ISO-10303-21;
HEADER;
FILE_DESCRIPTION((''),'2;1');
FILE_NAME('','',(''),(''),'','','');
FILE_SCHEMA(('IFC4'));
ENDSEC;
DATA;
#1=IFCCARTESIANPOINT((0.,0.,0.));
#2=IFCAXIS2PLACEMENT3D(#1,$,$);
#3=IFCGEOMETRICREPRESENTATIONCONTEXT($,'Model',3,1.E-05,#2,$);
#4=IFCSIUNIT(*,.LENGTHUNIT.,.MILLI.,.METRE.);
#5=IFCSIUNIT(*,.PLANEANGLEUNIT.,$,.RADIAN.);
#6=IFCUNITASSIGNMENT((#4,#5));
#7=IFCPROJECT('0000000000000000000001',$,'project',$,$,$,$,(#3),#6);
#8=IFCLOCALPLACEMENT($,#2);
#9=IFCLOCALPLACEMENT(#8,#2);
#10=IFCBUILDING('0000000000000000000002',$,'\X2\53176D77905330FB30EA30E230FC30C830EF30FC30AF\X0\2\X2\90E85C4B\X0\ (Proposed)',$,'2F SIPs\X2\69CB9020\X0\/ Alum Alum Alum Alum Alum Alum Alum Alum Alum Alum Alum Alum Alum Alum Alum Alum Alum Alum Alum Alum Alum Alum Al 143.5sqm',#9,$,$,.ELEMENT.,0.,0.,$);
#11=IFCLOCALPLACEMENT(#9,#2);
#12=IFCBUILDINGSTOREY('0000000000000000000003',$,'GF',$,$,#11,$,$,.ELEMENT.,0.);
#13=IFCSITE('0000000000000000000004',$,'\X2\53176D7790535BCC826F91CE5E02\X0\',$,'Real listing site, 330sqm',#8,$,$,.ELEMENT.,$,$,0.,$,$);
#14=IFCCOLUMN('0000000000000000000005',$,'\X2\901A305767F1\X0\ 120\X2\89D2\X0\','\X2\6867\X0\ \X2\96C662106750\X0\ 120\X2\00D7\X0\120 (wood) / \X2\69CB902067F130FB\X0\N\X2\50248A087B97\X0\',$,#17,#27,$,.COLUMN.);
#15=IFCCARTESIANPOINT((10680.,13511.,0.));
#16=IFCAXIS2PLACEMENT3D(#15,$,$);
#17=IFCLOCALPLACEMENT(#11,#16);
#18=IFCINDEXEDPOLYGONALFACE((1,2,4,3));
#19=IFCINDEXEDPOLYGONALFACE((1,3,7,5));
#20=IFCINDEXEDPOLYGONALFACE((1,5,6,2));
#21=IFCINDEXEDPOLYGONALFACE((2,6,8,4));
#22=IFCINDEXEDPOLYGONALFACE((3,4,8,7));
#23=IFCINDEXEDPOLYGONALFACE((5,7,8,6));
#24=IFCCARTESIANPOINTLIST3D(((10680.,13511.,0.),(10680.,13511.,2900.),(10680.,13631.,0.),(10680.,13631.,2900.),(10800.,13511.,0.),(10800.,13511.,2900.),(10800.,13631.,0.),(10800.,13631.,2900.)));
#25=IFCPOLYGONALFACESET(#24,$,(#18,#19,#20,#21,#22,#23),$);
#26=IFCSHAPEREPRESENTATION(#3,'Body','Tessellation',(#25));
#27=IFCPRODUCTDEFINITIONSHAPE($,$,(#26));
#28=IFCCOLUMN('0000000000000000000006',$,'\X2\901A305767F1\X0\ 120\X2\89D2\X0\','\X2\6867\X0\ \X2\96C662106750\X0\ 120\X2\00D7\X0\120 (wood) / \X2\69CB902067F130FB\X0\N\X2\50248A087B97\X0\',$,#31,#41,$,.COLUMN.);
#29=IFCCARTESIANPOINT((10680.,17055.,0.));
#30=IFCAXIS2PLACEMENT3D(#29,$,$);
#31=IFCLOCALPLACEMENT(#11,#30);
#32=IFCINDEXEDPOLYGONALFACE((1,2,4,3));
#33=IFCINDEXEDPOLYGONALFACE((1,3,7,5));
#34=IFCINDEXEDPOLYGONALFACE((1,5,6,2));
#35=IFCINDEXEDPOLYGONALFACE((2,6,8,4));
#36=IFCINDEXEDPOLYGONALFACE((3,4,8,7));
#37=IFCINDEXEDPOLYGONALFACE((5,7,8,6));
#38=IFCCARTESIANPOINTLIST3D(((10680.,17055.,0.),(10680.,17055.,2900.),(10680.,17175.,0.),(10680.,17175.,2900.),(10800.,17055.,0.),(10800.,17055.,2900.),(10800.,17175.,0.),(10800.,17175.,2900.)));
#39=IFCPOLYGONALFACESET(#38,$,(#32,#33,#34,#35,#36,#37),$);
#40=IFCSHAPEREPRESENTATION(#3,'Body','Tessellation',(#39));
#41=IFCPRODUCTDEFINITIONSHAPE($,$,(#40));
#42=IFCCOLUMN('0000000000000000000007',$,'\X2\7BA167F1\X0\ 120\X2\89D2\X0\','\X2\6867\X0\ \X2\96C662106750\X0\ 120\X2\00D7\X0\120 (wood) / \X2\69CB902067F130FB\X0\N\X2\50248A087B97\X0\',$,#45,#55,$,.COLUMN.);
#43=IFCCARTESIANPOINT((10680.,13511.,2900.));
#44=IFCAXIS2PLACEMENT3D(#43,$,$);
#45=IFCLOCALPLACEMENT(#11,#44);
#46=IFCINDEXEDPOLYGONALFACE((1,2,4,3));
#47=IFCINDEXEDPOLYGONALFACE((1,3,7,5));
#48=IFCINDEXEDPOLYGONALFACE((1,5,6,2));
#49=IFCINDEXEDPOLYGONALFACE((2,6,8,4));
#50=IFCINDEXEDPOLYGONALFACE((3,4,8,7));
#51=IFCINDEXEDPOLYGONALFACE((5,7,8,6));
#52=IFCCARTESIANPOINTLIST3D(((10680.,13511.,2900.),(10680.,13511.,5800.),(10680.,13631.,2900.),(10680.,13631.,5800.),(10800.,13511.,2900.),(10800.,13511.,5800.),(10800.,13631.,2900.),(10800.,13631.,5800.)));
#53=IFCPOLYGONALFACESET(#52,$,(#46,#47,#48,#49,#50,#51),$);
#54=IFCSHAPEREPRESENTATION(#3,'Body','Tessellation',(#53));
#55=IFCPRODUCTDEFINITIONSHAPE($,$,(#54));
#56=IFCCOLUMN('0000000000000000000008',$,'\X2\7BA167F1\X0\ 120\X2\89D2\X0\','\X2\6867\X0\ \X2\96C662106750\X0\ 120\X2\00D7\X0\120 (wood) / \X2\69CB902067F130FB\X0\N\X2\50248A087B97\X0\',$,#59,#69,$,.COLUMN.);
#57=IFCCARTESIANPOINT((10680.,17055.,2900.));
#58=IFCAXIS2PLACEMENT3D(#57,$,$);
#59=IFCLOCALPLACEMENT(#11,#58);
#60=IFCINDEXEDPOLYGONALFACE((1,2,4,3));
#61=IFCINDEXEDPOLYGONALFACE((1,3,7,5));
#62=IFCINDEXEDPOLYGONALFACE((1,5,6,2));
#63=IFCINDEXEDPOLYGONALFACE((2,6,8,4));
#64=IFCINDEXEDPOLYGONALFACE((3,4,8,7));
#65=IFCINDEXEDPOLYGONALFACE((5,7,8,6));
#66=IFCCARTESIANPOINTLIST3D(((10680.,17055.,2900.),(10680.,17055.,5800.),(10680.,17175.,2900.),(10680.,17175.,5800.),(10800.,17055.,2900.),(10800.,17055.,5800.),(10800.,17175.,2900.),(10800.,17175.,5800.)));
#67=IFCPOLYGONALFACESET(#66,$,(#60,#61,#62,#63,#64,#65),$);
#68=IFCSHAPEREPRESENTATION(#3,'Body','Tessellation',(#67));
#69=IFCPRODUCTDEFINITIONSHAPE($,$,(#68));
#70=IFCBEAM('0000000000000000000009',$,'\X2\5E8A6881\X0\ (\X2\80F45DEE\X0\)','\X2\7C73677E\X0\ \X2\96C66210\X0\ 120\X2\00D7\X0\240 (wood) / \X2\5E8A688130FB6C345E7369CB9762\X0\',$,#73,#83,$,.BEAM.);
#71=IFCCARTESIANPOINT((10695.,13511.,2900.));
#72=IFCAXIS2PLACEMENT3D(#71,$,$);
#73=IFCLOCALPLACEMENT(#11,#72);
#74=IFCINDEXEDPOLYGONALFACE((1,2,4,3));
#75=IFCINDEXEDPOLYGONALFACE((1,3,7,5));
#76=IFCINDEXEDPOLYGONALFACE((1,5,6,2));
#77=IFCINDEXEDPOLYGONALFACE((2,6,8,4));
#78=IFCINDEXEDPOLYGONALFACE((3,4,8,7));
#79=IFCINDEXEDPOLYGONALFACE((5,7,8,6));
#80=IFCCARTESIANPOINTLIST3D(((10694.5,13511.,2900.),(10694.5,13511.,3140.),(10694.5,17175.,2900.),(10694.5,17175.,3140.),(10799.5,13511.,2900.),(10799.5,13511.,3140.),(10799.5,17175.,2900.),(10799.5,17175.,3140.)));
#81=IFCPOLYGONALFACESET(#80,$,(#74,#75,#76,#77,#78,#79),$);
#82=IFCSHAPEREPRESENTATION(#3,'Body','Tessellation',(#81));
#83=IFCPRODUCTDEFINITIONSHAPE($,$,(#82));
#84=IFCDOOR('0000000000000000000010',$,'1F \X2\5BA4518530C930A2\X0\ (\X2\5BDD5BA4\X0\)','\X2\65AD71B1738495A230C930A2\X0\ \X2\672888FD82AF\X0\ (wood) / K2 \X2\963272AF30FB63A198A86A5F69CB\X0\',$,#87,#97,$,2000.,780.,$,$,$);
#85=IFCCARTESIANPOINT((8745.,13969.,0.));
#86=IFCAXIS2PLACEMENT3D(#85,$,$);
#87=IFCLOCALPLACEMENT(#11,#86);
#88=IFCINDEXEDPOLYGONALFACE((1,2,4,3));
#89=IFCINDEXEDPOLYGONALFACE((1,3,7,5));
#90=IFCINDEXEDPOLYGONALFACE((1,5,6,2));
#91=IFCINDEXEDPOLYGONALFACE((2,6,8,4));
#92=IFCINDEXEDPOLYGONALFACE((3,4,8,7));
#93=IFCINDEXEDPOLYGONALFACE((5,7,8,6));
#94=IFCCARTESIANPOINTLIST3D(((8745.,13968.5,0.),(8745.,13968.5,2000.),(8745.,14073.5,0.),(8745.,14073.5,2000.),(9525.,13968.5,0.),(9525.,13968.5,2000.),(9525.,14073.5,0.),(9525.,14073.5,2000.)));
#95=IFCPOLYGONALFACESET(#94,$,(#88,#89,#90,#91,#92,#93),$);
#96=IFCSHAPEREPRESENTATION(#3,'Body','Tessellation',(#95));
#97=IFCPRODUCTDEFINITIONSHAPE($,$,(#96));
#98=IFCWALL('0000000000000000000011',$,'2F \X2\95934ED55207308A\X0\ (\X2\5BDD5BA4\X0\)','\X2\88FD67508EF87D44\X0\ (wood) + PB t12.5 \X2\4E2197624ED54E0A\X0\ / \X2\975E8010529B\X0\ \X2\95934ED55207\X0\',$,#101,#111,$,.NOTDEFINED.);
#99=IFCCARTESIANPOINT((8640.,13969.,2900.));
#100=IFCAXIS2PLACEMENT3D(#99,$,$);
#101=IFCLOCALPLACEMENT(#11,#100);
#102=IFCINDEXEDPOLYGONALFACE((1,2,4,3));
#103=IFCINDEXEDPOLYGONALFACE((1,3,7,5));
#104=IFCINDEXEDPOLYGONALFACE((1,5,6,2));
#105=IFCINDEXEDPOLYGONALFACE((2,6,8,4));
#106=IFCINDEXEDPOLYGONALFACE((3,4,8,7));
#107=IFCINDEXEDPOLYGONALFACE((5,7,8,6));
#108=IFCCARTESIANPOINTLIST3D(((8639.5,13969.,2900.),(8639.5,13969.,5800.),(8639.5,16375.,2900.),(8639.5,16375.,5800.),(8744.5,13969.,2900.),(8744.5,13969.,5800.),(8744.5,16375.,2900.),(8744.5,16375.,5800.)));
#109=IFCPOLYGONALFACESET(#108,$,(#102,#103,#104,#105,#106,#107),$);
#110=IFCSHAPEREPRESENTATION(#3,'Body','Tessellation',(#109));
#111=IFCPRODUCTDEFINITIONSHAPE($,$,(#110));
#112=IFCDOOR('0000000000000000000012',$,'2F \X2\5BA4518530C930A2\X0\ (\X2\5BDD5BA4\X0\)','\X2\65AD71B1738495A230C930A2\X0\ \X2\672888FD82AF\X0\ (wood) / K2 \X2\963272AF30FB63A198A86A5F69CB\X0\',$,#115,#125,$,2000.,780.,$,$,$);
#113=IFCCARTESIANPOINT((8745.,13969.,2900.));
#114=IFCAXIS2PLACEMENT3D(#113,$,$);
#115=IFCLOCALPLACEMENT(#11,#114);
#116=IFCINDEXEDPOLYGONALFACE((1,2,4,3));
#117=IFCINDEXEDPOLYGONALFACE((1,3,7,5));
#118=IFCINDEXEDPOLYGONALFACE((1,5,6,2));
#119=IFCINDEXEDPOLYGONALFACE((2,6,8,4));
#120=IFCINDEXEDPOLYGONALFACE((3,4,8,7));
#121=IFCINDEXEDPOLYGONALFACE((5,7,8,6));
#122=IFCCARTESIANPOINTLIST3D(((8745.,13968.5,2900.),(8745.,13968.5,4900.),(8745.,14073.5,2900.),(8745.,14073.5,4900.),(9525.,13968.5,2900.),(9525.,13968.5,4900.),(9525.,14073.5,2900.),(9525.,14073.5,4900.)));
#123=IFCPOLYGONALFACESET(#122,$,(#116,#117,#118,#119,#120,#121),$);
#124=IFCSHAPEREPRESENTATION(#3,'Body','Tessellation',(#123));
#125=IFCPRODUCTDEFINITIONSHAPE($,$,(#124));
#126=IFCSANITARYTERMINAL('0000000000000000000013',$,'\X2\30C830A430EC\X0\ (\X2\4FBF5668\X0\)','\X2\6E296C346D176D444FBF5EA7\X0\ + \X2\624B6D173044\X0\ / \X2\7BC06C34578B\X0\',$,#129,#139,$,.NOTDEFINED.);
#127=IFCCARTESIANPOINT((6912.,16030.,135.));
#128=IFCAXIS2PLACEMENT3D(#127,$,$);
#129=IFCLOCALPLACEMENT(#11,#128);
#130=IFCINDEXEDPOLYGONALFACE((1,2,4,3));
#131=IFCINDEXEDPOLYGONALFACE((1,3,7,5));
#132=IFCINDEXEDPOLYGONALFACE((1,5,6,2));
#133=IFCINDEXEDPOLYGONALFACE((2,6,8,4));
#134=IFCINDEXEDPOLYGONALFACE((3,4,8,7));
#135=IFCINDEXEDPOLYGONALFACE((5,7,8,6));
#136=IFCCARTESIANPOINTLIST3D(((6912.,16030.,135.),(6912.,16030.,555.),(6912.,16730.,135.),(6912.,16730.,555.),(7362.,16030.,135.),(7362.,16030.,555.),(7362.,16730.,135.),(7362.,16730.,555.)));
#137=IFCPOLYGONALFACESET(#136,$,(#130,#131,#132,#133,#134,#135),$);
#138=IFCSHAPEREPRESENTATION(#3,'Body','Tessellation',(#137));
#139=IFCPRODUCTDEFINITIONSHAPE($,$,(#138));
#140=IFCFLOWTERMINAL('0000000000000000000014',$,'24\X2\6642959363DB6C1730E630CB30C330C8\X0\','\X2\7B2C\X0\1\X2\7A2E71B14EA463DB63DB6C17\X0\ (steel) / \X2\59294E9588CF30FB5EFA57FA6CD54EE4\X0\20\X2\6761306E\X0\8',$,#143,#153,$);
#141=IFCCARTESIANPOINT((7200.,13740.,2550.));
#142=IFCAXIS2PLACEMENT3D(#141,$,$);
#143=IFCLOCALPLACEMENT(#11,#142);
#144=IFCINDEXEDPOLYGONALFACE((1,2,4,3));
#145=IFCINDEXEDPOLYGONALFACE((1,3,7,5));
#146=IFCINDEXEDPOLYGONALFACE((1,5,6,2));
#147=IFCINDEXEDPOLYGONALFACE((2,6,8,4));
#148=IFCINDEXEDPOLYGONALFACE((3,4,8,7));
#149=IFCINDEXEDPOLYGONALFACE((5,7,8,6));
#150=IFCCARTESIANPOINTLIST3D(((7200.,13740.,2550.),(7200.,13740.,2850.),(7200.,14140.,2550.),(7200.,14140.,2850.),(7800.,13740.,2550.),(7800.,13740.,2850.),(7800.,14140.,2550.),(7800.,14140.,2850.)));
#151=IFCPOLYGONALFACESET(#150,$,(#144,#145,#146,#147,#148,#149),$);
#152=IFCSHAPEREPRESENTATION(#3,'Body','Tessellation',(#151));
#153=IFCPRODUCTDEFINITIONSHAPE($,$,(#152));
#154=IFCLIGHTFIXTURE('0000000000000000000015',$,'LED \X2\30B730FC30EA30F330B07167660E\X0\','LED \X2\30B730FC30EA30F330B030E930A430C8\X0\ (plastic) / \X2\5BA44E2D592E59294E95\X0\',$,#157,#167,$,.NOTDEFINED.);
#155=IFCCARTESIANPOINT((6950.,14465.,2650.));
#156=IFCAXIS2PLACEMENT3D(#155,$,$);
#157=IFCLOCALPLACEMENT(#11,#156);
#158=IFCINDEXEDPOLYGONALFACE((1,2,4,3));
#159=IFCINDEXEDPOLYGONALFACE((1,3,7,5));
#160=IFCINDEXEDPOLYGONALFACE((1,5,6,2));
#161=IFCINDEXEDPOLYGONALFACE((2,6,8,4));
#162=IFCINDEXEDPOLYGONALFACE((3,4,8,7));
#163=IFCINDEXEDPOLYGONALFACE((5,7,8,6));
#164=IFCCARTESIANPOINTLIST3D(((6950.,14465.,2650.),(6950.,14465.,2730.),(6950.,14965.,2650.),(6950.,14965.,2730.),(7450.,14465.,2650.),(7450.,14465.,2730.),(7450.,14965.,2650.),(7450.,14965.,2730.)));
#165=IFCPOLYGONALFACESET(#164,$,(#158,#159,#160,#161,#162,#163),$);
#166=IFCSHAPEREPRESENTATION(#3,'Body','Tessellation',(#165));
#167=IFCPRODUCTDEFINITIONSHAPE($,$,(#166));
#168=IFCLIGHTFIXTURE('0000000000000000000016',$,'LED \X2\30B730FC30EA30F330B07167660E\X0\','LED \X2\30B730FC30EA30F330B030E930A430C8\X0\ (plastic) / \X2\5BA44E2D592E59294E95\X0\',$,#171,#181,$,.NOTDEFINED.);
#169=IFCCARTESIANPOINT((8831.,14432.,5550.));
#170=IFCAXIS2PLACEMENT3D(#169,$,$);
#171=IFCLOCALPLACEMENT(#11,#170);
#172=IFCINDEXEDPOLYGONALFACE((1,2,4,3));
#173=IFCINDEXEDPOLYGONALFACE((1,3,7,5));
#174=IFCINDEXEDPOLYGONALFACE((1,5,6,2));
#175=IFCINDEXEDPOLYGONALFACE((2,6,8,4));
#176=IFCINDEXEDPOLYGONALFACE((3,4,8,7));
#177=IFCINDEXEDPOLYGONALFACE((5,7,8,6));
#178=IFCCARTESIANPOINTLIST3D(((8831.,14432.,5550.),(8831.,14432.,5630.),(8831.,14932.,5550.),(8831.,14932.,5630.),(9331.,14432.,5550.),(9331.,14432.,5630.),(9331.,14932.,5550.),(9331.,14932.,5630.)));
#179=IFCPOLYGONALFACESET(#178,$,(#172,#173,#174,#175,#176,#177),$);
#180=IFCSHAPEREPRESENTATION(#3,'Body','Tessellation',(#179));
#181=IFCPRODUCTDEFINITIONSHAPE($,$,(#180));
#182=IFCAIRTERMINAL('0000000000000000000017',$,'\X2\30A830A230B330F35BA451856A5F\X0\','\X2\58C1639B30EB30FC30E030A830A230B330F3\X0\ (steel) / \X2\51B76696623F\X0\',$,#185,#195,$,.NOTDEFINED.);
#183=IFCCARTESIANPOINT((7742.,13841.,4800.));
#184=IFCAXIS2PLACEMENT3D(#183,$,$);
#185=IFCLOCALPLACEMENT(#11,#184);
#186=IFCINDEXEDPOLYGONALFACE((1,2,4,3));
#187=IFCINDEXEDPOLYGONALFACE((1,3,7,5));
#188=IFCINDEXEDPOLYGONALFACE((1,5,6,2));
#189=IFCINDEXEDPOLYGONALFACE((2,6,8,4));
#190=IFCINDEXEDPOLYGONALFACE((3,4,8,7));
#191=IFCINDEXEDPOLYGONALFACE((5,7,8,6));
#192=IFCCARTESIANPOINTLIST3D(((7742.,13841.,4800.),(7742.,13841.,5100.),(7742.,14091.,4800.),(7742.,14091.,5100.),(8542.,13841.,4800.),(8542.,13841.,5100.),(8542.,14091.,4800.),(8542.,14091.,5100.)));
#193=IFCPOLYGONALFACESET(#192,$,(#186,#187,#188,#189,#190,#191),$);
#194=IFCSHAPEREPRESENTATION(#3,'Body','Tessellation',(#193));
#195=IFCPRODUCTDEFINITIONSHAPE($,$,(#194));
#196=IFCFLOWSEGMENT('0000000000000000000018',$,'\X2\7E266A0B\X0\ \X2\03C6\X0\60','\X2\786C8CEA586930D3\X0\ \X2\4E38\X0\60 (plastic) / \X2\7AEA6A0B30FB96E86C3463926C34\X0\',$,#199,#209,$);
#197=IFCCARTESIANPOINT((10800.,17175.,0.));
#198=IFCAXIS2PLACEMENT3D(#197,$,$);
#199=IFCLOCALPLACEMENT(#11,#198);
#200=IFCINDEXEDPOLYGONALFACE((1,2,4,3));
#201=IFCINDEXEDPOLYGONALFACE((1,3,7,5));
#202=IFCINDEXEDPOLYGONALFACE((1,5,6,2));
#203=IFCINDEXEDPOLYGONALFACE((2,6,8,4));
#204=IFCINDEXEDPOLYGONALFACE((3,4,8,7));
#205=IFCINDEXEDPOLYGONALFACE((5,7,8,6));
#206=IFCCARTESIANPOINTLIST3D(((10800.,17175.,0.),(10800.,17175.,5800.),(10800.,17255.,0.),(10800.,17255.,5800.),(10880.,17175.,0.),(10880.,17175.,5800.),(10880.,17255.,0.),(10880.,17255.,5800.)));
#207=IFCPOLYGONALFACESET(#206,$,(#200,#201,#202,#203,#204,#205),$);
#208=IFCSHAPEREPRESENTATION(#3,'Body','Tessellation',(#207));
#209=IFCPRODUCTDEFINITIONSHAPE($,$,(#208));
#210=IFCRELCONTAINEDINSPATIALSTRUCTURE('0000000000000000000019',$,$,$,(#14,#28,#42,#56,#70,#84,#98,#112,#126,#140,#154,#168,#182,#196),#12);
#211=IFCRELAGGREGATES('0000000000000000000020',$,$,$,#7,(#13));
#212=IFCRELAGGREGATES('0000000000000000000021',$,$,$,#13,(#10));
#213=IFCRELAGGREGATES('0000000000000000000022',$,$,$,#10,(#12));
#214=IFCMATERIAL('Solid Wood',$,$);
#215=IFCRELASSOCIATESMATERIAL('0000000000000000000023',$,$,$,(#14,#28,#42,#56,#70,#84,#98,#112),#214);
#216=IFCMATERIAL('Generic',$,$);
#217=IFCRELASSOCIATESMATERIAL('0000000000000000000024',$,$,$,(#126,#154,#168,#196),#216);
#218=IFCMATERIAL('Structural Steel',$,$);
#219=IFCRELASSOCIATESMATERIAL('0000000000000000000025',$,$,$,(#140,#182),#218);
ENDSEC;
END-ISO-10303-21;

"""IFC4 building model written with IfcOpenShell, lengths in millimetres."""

from ifc_helpers import new_model, si_unit, frame, frame_2d, origin, place, context, project, spatial, rectangle, extrude, material, element, save


model = new_model("IFC4")

# Units and contexts
model_context = context("Model", 3, precision=1e-05, world=origin())
ifc_project = project(units=[si_unit("LENGTHUNIT", "METRE", prefix="MILLI"), si_unit("PLANEANGLEUNIT", "RADIAN")], contexts=[model_context])

# Site, building, storey
site_placement = place(None, origin())
site = spatial("IfcSite", under=ifc_project, at=site_placement, Name="北海道富良野市", ObjectType="Real listing site, 330sqm", CompositionType="ELEMENT", RefElevation=0.0)
building_placement = place(site_placement, origin())
building = spatial("IfcBuilding", under=site, at=building_placement, Name="北海道・リモートワーク2部屋 (Proposed)", ObjectType="2F SIPs構造/ Alum Alum Alum Alum Alum Alum Alum Alum Alum Alum Alum Alum Alum Alum Alum Alum Alum Alum Alum Alum Alum Alum Al 143.5sqm", CompositionType="ELEMENT", ElevationOfRefHeight=0.0, ElevationOfTerrain=0.0)
storey_placement = place(building_placement, origin())
storey = spatial("IfcBuildingStorey", under=building, at=storey_placement, Name="GF", CompositionType="ELEMENT", Elevation=0.0)

# Columns
ifc_material_1 = material(Name="Solid Wood")
column_1_placement = place(storey_placement, frame((10680.0, 13511.0, 0.0)))
element("IfcColumn", 1, at=column_1_placement, inside=storey, material=ifc_material_1, Name="通し柱 120角", Description="桧 集成材 120×120 (wood) / 構造柱・N値計算", PredefinedType="COLUMN", context=model_context, shape_type="SweptSolid", body=[
    extrude(rectangle(XDim=120.0, YDim=120.0, at=frame_2d((60.0, 60.0))), frame((10680.0, 13511.0, 0.0)), (0.0, 0.0, 1.0), 2900.0),
])
column_2_placement = place(storey_placement, frame((10680.0, 17055.0, 0.0)))
element("IfcColumn", 2, at=column_2_placement, inside=storey, material=ifc_material_1, Name="通し柱 120角", Description="桧 集成材 120×120 (wood) / 構造柱・N値計算", PredefinedType="COLUMN", context=model_context, shape_type="SweptSolid", body=[
    extrude(rectangle(XDim=120.0, YDim=120.0, at=frame_2d((60.0, 60.0))), frame((10680.0, 17055.0, 0.0)), (0.0, 0.0, 1.0), 2900.0),
])
column_3_placement = place(storey_placement, frame((10680.0, 13511.0, 2900.0)))
element("IfcColumn", 3, at=column_3_placement, inside=storey, material=ifc_material_1, Name="管柱 120角", Description="桧 集成材 120×120 (wood) / 構造柱・N値計算", PredefinedType="COLUMN", context=model_context, shape_type="SweptSolid", body=[
    extrude(rectangle(XDim=120.0, YDim=120.0, at=frame_2d((60.0, 60.0))), frame((10680.0, 13511.0, 2900.0)), (0.0, 0.0, 1.0), 2900.0),
])
column_4_placement = place(storey_placement, frame((10680.0, 17055.0, 2900.0)))
element("IfcColumn", 4, at=column_4_placement, inside=storey, material=ifc_material_1, Name="管柱 120角", Description="桧 集成材 120×120 (wood) / 構造柱・N値計算", PredefinedType="COLUMN", context=model_context, shape_type="SweptSolid", body=[
    extrude(rectangle(XDim=120.0, YDim=120.0, at=frame_2d((60.0, 60.0))), frame((10680.0, 17055.0, 2900.0)), (0.0, 0.0, 1.0), 2900.0),
])

# Beam
beam_1_placement = place(storey_placement, frame((10695.0, 13511.0, 2900.0)))
element("IfcBeam", 5, at=beam_1_placement, inside=storey, material=ifc_material_1, Name="床梁 (胴差)", Description="米松 集成 120×240 (wood) / 床梁・水平構面", PredefinedType="BEAM", context=model_context, shape_type="SweptSolid", body=[
    extrude(rectangle(XDim=105.0, YDim=3664.0, at=frame_2d((52.0, 1832.0))), frame((10695.0, 13511.0, 2900.0)), (0.0, 0.0, 1.0), 240.0),
])

# Door
door_1_placement = place(storey_placement, frame((8745.0, 13969.0, 0.0)))
element("IfcDoor", 6, at=door_1_placement, inside=storey, material=ifc_material_1, Name="1F 室内ドア (寝室)", Description="断熱玄関ドア 木製芯 (wood) / K2 防犯・採風機構", OverallHeight=2000.0, OverallWidth=780.0, context=model_context, shape_type="SweptSolid", body=[
    extrude(rectangle(XDim=780.0, YDim=105.0, at=frame_2d((390.0, 52.0))), frame((8745.0, 13969.0, 0.0)), (0.0, 0.0, 1.0), 2000.0),
])

# Wall
wall_1_placement = place(storey_placement, frame((8640.0, 13969.0, 2900.0)))
element("IfcWall", 7, at=wall_1_placement, inside=storey, material=ifc_material_1, Name="2F 間仕切り (寝室)", Description="製材軸組 (wood) + PB t12.5 両面仕上 / 非耐力 間仕切", PredefinedType="NOTDEFINED", context=model_context, shape_type="SweptSolid", body=[
    extrude(rectangle(XDim=105.0, YDim=2406.0, at=frame_2d((52.0, 1203.0))), frame((8640.0, 13969.0, 2900.0)), (0.0, 0.0, 1.0), 2900.0),
])

# Door
door_2_placement = place(storey_placement, frame((8745.0, 13969.0, 2900.0)))
element("IfcDoor", 8, at=door_2_placement, inside=storey, material=ifc_material_1, Name="2F 室内ドア (寝室)", Description="断熱玄関ドア 木製芯 (wood) / K2 防犯・採風機構", OverallHeight=2000.0, OverallWidth=780.0, context=model_context, shape_type="SweptSolid", body=[
    extrude(rectangle(XDim=780.0, YDim=105.0, at=frame_2d((390.0, 52.0))), frame((8745.0, 13969.0, 2900.0)), (0.0, 0.0, 1.0), 2000.0),
])

# Sanitary terminal
ifc_material_2 = material(Name="Generic")
sanitary_terminal_placement = place(storey_placement, frame((6912.0, 16030.0, 135.0)))
element("IfcSanitaryTerminal", 9, at=sanitary_terminal_placement, inside=storey, material=ifc_material_2, Name="トイレ (便器)", Description="温水洗浄便座 + 手洗い / 節水型", PredefinedType="NOTDEFINED", context=model_context, shape_type="SweptSolid", body=[
    extrude(rectangle(XDim=450.0, YDim=700.0, at=frame_2d((225.0, 350.0))), frame((6912.0, 16030.0, 135.0)), (0.0, 0.0, 1.0), 420.0),
])

# Flow terminal
ifc_material_3 = material(Name="Structural Steel")
flow_terminal_placement = place(storey_placement, frame((7200.0, 13740.0, 2550.0)))
element("IfcFlowTerminal", 10, at=flow_terminal_placement, inside=storey, material=ifc_material_3, Name="24時間換気ユニット", Description="第1種熱交換換気 (steel) / 天井裏・建基法令20条の8", context=model_context, shape_type="SweptSolid", body=[
    extrude(rectangle(XDim=600.0, YDim=400.0, at=frame_2d((300.0, 200.0))), frame((7200.0, 13740.0, 2550.0)), (0.0, 0.0, 1.0), 300.0),
])

# Light fixtures
light_fixture_1_placement = place(storey_placement, frame((6950.0, 14465.0, 2650.0)))
element("IfcLightFixture", 11, at=light_fixture_1_placement, inside=storey, material=ifc_material_2, Name="LED シーリング照明", Description="LED シーリングライト (plastic) / 室中央天井", PredefinedType="NOTDEFINED", context=model_context, shape_type="SweptSolid", body=[
    extrude(rectangle(XDim=500.0, YDim=500.0, at=frame_2d((250.0, 250.0))), frame((6950.0, 14465.0, 2650.0)), (0.0, 0.0, 1.0), 80.0),
])
light_fixture_2_placement = place(storey_placement, frame((8831.0, 14432.0, 5550.0)))
element("IfcLightFixture", 12, at=light_fixture_2_placement, inside=storey, material=ifc_material_2, Name="LED シーリング照明", Description="LED シーリングライト (plastic) / 室中央天井", PredefinedType="NOTDEFINED", context=model_context, shape_type="SweptSolid", body=[
    extrude(rectangle(XDim=500.0, YDim=500.0, at=frame_2d((250.0, 250.0))), frame((8831.0, 14432.0, 5550.0)), (0.0, 0.0, 1.0), 80.0),
])

# Air terminal
air_terminal_placement = place(storey_placement, frame((7742.0, 13841.0, 4800.0)))
element("IfcAirTerminal", 13, at=air_terminal_placement, inside=storey, material=ifc_material_3, Name="エアコン室内機", Description="壁掛ルームエアコン (steel) / 冷暖房", PredefinedType="NOTDEFINED", context=model_context, shape_type="SweptSolid", body=[
    extrude(rectangle(XDim=800.0, YDim=250.0, at=frame_2d((400.0, 125.0))), frame((7742.0, 13841.0, 4800.0)), (0.0, 0.0, 1.0), 300.0),
])

# Flow segment
flow_segment_placement = place(storey_placement, frame((10800.0, 17175.0, 0.0)))
element("IfcFlowSegment", 14, at=flow_segment_placement, inside=storey, material=ifc_material_2, Name="縦樋 φ60", Description="硬質塩ビ 丸60 (plastic) / 竪樋・雨水排水", context=model_context, shape_type="SweptSolid", body=[
    extrude(rectangle(XDim=80.0, YDim=80.0, at=frame_2d((40.0, 40.0))), frame((10800.0, 17175.0, 0.0)), (0.0, 0.0, 1.0), 5800.0),
])

save(model, "model.ifc")
